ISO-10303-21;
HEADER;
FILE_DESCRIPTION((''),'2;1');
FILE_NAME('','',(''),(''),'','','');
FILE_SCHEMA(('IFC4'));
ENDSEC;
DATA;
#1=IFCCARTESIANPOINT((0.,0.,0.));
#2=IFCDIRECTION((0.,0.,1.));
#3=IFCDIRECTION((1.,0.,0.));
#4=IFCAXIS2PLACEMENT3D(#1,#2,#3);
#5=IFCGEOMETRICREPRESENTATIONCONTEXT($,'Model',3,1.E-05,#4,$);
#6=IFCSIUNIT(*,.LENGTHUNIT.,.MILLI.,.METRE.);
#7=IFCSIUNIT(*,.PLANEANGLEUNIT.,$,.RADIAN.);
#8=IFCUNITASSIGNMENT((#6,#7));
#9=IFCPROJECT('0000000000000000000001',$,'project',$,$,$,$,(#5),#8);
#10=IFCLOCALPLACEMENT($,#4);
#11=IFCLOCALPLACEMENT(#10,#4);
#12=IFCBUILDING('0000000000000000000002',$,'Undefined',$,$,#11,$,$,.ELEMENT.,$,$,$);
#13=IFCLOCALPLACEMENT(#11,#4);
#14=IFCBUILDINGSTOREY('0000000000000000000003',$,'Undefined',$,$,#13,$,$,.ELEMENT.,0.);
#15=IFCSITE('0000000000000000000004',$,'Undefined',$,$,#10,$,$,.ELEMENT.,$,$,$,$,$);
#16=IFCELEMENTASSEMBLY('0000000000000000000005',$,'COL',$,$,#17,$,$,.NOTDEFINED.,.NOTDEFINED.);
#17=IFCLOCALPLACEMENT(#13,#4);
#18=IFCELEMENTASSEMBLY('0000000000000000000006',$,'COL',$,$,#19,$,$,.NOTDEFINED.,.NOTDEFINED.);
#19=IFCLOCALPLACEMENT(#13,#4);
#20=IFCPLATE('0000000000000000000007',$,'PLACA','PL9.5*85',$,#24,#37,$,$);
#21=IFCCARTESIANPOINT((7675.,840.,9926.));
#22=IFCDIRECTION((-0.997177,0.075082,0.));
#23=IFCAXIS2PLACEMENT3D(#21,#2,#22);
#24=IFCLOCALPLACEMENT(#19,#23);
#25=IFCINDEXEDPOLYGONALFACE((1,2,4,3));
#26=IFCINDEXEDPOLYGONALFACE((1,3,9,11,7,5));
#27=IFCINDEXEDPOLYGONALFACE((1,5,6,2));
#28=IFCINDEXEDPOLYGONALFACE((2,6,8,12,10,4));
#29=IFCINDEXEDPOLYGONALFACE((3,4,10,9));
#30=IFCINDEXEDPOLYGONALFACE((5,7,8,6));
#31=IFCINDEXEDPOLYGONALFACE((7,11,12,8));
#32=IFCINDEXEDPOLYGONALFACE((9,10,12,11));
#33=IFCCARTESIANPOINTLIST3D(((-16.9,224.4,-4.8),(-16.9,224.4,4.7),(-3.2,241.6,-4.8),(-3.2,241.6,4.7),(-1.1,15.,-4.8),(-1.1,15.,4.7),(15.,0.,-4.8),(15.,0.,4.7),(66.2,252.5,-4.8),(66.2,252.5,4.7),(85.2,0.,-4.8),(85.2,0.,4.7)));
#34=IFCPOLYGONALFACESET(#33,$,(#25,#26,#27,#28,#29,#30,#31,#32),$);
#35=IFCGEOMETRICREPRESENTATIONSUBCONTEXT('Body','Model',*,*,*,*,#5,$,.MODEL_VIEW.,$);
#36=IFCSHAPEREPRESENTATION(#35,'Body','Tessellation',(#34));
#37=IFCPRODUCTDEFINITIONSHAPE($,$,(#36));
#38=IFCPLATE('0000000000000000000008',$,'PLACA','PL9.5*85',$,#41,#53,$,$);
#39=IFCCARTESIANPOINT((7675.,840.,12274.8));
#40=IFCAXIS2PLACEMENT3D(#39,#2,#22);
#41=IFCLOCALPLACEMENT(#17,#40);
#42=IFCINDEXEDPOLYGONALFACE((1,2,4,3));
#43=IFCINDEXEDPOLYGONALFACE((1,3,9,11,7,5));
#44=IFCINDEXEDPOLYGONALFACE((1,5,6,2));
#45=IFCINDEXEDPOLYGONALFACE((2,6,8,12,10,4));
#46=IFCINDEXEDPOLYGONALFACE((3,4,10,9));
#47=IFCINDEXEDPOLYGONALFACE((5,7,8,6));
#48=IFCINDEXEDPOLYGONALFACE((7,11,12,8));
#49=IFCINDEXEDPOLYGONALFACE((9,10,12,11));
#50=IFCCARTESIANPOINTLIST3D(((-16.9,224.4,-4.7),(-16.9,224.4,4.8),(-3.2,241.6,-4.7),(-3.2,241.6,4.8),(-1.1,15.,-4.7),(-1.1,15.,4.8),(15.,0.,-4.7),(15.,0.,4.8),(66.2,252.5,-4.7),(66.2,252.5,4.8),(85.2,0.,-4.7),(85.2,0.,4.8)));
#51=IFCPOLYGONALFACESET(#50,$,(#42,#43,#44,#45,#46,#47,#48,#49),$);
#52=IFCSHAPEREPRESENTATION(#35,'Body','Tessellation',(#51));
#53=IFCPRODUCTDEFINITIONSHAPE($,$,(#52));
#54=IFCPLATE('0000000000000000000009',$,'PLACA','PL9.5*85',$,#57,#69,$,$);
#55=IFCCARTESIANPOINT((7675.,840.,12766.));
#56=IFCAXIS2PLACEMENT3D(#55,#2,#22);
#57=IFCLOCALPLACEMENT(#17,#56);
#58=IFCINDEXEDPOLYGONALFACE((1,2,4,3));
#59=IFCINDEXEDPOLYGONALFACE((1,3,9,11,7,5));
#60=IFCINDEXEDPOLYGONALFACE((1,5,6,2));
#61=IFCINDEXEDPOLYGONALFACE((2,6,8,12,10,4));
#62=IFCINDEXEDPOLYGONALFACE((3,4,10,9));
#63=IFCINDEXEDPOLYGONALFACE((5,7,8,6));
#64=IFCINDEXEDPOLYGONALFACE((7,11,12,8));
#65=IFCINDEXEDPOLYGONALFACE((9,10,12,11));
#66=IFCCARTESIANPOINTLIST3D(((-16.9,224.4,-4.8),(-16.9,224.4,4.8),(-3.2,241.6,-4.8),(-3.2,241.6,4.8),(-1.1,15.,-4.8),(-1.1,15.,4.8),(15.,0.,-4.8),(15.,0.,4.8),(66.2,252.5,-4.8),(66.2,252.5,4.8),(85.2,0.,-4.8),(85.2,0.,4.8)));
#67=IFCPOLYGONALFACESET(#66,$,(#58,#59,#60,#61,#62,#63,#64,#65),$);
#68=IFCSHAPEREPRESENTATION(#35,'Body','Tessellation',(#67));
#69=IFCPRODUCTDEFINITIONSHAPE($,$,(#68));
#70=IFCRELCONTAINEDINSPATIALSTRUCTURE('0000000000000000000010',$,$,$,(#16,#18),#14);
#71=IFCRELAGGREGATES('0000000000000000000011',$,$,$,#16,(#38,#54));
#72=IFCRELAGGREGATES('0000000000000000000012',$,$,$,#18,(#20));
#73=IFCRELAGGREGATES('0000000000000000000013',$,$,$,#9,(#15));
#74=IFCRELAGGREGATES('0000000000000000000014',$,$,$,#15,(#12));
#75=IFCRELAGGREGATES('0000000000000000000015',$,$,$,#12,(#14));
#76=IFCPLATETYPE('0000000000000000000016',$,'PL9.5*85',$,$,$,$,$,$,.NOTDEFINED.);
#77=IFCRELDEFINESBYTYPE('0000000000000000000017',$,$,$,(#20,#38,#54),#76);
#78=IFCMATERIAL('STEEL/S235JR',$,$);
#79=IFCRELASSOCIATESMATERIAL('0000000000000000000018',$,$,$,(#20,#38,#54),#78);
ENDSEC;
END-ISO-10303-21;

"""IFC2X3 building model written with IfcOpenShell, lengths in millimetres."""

from ifc_helpers import new_model, si_unit, frame, origin_with_axes, place, context, subcontext, project, spatial, polyline, outline, extrude, material, type_object, element, aggregate, save


model = new_model("IFC2X3")

# Units and contexts
model_context = context("Model", 3, precision=1e-05, world=origin_with_axes())
body_context = subcontext(model_context, "Body", "Model", "MODEL_VIEW")
ifc_project = project(units=[si_unit("LENGTHUNIT", "METRE", prefix="MILLI"), si_unit("PLANEANGLEUNIT", "RADIAN")], contexts=[model_context])

# Site, building, storey
site_placement = place(None, origin_with_axes())
site = spatial("IfcSite", under=ifc_project, at=site_placement, Name="Undefined", CompositionType="ELEMENT")
building_placement = place(site_placement, origin_with_axes())
building = spatial("IfcBuilding", under=site, at=building_placement, Name="Undefined", CompositionType="ELEMENT")
storey_placement = place(building_placement, origin_with_axes())
storey = spatial("IfcBuildingStorey", under=building, at=storey_placement, Name="Undefined", CompositionType="ELEMENT", Elevation=0.0)

# Shared definitions
ifc_material_1 = material(Name="STEEL/S235JR")

# Element assembly
assembly_1_placement = place(storey_placement, origin_with_axes())
assembly_1 = element("IfcElementAssembly", 1, at=assembly_1_placement, inside=storey, Name="COL", AssemblyPlace="NOTDEFINED", PredefinedType="NOTDEFINED")

# Element assembly, plate
assembly_2_placement = place(storey_placement, origin_with_axes())
assembly_2 = element("IfcElementAssembly", 2, at=assembly_2_placement, inside=storey, Name="COL", AssemblyPlace="NOTDEFINED", PredefinedType="NOTDEFINED")
plate_type_1 = type_object("IfcPlateType", Name="PL9.5*85", PredefinedType="NOTDEFINED")
plate_1_placement = place(assembly_2_placement, frame((7675.0, 840.0, 9926.0), z_axis=(0.0, 0.0, 1.0), x_axis=(-0.997177, 0.075082, 0.0)))
plate_1 = element("IfcPlate", 3, at=plate_1_placement, type_object=plate_type_1, material=ifc_material_1, Name="PLACA", Description="PL9.5*85", context=body_context, shape_type="SweptSolid", body=[
    extrude(outline(polyline([(-1.1, 15.0), (15.0, 0.0), (85.2, 0.0), (66.2, 252.5), (-3.2, 241.6), (-16.9, 224.4), (-1.1, 15.0)])), frame((0.0, 0.0, -4.7), z_axis=(0.0, 0.0, 1.0), x_axis=(1.0, 0.0, 0.0)), (0.0, 0.0, 1.0), 9.5),
])

# Plates
plate_2_placement = place(assembly_1_placement, frame((7675.0, 840.0, 12274.8), z_axis=(0.0, 0.0, 1.0), x_axis=(-0.997177, 0.075082, 0.0)))
plate_2 = element("IfcPlate", 4, at=plate_2_placement, type_object=plate_type_1, material=ifc_material_1, Name="PLACA", Description="PL9.5*85", context=body_context, shape_type="SweptSolid", body=[
    extrude(outline(polyline([(-1.1, 15.0), (15.0, 0.0), (85.2, 0.0), (66.2, 252.5), (-3.2, 241.6), (-16.9, 224.4), (-1.1, 15.0)])), frame((0.0, 0.0, -4.7), z_axis=(0.0, 0.0, 1.0), x_axis=(1.0, 0.0, 0.0)), (0.0, 0.0, 1.0), 9.5),
])
plate_3_placement = place(assembly_1_placement, frame((7675.0, 840.0, 12766.0), z_axis=(0.0, 0.0, 1.0), x_axis=(-0.997177, 0.075082, 0.0)))
plate_3 = element("IfcPlate", 5, at=plate_3_placement, type_object=plate_type_1, material=ifc_material_1, Name="PLACA", Description="PL9.5*85", context=body_context, shape_type="SweptSolid", body=[
    extrude(outline(polyline([(-1.1, 15.0), (15.0, 0.0), (85.2, 0.0), (66.2, 252.5), (-3.2, 241.6), (-16.9, 224.4), (-1.1, 15.0)])), frame((0.0, 0.0, -4.7), z_axis=(0.0, 0.0, 1.0), x_axis=(1.0, 0.0, 0.0)), (0.0, 0.0, 1.0), 9.5),
])
aggregate(assembly_1, [plate_2, plate_3])
aggregate(assembly_2, [plate_1])

save(model, "model.ifc")
